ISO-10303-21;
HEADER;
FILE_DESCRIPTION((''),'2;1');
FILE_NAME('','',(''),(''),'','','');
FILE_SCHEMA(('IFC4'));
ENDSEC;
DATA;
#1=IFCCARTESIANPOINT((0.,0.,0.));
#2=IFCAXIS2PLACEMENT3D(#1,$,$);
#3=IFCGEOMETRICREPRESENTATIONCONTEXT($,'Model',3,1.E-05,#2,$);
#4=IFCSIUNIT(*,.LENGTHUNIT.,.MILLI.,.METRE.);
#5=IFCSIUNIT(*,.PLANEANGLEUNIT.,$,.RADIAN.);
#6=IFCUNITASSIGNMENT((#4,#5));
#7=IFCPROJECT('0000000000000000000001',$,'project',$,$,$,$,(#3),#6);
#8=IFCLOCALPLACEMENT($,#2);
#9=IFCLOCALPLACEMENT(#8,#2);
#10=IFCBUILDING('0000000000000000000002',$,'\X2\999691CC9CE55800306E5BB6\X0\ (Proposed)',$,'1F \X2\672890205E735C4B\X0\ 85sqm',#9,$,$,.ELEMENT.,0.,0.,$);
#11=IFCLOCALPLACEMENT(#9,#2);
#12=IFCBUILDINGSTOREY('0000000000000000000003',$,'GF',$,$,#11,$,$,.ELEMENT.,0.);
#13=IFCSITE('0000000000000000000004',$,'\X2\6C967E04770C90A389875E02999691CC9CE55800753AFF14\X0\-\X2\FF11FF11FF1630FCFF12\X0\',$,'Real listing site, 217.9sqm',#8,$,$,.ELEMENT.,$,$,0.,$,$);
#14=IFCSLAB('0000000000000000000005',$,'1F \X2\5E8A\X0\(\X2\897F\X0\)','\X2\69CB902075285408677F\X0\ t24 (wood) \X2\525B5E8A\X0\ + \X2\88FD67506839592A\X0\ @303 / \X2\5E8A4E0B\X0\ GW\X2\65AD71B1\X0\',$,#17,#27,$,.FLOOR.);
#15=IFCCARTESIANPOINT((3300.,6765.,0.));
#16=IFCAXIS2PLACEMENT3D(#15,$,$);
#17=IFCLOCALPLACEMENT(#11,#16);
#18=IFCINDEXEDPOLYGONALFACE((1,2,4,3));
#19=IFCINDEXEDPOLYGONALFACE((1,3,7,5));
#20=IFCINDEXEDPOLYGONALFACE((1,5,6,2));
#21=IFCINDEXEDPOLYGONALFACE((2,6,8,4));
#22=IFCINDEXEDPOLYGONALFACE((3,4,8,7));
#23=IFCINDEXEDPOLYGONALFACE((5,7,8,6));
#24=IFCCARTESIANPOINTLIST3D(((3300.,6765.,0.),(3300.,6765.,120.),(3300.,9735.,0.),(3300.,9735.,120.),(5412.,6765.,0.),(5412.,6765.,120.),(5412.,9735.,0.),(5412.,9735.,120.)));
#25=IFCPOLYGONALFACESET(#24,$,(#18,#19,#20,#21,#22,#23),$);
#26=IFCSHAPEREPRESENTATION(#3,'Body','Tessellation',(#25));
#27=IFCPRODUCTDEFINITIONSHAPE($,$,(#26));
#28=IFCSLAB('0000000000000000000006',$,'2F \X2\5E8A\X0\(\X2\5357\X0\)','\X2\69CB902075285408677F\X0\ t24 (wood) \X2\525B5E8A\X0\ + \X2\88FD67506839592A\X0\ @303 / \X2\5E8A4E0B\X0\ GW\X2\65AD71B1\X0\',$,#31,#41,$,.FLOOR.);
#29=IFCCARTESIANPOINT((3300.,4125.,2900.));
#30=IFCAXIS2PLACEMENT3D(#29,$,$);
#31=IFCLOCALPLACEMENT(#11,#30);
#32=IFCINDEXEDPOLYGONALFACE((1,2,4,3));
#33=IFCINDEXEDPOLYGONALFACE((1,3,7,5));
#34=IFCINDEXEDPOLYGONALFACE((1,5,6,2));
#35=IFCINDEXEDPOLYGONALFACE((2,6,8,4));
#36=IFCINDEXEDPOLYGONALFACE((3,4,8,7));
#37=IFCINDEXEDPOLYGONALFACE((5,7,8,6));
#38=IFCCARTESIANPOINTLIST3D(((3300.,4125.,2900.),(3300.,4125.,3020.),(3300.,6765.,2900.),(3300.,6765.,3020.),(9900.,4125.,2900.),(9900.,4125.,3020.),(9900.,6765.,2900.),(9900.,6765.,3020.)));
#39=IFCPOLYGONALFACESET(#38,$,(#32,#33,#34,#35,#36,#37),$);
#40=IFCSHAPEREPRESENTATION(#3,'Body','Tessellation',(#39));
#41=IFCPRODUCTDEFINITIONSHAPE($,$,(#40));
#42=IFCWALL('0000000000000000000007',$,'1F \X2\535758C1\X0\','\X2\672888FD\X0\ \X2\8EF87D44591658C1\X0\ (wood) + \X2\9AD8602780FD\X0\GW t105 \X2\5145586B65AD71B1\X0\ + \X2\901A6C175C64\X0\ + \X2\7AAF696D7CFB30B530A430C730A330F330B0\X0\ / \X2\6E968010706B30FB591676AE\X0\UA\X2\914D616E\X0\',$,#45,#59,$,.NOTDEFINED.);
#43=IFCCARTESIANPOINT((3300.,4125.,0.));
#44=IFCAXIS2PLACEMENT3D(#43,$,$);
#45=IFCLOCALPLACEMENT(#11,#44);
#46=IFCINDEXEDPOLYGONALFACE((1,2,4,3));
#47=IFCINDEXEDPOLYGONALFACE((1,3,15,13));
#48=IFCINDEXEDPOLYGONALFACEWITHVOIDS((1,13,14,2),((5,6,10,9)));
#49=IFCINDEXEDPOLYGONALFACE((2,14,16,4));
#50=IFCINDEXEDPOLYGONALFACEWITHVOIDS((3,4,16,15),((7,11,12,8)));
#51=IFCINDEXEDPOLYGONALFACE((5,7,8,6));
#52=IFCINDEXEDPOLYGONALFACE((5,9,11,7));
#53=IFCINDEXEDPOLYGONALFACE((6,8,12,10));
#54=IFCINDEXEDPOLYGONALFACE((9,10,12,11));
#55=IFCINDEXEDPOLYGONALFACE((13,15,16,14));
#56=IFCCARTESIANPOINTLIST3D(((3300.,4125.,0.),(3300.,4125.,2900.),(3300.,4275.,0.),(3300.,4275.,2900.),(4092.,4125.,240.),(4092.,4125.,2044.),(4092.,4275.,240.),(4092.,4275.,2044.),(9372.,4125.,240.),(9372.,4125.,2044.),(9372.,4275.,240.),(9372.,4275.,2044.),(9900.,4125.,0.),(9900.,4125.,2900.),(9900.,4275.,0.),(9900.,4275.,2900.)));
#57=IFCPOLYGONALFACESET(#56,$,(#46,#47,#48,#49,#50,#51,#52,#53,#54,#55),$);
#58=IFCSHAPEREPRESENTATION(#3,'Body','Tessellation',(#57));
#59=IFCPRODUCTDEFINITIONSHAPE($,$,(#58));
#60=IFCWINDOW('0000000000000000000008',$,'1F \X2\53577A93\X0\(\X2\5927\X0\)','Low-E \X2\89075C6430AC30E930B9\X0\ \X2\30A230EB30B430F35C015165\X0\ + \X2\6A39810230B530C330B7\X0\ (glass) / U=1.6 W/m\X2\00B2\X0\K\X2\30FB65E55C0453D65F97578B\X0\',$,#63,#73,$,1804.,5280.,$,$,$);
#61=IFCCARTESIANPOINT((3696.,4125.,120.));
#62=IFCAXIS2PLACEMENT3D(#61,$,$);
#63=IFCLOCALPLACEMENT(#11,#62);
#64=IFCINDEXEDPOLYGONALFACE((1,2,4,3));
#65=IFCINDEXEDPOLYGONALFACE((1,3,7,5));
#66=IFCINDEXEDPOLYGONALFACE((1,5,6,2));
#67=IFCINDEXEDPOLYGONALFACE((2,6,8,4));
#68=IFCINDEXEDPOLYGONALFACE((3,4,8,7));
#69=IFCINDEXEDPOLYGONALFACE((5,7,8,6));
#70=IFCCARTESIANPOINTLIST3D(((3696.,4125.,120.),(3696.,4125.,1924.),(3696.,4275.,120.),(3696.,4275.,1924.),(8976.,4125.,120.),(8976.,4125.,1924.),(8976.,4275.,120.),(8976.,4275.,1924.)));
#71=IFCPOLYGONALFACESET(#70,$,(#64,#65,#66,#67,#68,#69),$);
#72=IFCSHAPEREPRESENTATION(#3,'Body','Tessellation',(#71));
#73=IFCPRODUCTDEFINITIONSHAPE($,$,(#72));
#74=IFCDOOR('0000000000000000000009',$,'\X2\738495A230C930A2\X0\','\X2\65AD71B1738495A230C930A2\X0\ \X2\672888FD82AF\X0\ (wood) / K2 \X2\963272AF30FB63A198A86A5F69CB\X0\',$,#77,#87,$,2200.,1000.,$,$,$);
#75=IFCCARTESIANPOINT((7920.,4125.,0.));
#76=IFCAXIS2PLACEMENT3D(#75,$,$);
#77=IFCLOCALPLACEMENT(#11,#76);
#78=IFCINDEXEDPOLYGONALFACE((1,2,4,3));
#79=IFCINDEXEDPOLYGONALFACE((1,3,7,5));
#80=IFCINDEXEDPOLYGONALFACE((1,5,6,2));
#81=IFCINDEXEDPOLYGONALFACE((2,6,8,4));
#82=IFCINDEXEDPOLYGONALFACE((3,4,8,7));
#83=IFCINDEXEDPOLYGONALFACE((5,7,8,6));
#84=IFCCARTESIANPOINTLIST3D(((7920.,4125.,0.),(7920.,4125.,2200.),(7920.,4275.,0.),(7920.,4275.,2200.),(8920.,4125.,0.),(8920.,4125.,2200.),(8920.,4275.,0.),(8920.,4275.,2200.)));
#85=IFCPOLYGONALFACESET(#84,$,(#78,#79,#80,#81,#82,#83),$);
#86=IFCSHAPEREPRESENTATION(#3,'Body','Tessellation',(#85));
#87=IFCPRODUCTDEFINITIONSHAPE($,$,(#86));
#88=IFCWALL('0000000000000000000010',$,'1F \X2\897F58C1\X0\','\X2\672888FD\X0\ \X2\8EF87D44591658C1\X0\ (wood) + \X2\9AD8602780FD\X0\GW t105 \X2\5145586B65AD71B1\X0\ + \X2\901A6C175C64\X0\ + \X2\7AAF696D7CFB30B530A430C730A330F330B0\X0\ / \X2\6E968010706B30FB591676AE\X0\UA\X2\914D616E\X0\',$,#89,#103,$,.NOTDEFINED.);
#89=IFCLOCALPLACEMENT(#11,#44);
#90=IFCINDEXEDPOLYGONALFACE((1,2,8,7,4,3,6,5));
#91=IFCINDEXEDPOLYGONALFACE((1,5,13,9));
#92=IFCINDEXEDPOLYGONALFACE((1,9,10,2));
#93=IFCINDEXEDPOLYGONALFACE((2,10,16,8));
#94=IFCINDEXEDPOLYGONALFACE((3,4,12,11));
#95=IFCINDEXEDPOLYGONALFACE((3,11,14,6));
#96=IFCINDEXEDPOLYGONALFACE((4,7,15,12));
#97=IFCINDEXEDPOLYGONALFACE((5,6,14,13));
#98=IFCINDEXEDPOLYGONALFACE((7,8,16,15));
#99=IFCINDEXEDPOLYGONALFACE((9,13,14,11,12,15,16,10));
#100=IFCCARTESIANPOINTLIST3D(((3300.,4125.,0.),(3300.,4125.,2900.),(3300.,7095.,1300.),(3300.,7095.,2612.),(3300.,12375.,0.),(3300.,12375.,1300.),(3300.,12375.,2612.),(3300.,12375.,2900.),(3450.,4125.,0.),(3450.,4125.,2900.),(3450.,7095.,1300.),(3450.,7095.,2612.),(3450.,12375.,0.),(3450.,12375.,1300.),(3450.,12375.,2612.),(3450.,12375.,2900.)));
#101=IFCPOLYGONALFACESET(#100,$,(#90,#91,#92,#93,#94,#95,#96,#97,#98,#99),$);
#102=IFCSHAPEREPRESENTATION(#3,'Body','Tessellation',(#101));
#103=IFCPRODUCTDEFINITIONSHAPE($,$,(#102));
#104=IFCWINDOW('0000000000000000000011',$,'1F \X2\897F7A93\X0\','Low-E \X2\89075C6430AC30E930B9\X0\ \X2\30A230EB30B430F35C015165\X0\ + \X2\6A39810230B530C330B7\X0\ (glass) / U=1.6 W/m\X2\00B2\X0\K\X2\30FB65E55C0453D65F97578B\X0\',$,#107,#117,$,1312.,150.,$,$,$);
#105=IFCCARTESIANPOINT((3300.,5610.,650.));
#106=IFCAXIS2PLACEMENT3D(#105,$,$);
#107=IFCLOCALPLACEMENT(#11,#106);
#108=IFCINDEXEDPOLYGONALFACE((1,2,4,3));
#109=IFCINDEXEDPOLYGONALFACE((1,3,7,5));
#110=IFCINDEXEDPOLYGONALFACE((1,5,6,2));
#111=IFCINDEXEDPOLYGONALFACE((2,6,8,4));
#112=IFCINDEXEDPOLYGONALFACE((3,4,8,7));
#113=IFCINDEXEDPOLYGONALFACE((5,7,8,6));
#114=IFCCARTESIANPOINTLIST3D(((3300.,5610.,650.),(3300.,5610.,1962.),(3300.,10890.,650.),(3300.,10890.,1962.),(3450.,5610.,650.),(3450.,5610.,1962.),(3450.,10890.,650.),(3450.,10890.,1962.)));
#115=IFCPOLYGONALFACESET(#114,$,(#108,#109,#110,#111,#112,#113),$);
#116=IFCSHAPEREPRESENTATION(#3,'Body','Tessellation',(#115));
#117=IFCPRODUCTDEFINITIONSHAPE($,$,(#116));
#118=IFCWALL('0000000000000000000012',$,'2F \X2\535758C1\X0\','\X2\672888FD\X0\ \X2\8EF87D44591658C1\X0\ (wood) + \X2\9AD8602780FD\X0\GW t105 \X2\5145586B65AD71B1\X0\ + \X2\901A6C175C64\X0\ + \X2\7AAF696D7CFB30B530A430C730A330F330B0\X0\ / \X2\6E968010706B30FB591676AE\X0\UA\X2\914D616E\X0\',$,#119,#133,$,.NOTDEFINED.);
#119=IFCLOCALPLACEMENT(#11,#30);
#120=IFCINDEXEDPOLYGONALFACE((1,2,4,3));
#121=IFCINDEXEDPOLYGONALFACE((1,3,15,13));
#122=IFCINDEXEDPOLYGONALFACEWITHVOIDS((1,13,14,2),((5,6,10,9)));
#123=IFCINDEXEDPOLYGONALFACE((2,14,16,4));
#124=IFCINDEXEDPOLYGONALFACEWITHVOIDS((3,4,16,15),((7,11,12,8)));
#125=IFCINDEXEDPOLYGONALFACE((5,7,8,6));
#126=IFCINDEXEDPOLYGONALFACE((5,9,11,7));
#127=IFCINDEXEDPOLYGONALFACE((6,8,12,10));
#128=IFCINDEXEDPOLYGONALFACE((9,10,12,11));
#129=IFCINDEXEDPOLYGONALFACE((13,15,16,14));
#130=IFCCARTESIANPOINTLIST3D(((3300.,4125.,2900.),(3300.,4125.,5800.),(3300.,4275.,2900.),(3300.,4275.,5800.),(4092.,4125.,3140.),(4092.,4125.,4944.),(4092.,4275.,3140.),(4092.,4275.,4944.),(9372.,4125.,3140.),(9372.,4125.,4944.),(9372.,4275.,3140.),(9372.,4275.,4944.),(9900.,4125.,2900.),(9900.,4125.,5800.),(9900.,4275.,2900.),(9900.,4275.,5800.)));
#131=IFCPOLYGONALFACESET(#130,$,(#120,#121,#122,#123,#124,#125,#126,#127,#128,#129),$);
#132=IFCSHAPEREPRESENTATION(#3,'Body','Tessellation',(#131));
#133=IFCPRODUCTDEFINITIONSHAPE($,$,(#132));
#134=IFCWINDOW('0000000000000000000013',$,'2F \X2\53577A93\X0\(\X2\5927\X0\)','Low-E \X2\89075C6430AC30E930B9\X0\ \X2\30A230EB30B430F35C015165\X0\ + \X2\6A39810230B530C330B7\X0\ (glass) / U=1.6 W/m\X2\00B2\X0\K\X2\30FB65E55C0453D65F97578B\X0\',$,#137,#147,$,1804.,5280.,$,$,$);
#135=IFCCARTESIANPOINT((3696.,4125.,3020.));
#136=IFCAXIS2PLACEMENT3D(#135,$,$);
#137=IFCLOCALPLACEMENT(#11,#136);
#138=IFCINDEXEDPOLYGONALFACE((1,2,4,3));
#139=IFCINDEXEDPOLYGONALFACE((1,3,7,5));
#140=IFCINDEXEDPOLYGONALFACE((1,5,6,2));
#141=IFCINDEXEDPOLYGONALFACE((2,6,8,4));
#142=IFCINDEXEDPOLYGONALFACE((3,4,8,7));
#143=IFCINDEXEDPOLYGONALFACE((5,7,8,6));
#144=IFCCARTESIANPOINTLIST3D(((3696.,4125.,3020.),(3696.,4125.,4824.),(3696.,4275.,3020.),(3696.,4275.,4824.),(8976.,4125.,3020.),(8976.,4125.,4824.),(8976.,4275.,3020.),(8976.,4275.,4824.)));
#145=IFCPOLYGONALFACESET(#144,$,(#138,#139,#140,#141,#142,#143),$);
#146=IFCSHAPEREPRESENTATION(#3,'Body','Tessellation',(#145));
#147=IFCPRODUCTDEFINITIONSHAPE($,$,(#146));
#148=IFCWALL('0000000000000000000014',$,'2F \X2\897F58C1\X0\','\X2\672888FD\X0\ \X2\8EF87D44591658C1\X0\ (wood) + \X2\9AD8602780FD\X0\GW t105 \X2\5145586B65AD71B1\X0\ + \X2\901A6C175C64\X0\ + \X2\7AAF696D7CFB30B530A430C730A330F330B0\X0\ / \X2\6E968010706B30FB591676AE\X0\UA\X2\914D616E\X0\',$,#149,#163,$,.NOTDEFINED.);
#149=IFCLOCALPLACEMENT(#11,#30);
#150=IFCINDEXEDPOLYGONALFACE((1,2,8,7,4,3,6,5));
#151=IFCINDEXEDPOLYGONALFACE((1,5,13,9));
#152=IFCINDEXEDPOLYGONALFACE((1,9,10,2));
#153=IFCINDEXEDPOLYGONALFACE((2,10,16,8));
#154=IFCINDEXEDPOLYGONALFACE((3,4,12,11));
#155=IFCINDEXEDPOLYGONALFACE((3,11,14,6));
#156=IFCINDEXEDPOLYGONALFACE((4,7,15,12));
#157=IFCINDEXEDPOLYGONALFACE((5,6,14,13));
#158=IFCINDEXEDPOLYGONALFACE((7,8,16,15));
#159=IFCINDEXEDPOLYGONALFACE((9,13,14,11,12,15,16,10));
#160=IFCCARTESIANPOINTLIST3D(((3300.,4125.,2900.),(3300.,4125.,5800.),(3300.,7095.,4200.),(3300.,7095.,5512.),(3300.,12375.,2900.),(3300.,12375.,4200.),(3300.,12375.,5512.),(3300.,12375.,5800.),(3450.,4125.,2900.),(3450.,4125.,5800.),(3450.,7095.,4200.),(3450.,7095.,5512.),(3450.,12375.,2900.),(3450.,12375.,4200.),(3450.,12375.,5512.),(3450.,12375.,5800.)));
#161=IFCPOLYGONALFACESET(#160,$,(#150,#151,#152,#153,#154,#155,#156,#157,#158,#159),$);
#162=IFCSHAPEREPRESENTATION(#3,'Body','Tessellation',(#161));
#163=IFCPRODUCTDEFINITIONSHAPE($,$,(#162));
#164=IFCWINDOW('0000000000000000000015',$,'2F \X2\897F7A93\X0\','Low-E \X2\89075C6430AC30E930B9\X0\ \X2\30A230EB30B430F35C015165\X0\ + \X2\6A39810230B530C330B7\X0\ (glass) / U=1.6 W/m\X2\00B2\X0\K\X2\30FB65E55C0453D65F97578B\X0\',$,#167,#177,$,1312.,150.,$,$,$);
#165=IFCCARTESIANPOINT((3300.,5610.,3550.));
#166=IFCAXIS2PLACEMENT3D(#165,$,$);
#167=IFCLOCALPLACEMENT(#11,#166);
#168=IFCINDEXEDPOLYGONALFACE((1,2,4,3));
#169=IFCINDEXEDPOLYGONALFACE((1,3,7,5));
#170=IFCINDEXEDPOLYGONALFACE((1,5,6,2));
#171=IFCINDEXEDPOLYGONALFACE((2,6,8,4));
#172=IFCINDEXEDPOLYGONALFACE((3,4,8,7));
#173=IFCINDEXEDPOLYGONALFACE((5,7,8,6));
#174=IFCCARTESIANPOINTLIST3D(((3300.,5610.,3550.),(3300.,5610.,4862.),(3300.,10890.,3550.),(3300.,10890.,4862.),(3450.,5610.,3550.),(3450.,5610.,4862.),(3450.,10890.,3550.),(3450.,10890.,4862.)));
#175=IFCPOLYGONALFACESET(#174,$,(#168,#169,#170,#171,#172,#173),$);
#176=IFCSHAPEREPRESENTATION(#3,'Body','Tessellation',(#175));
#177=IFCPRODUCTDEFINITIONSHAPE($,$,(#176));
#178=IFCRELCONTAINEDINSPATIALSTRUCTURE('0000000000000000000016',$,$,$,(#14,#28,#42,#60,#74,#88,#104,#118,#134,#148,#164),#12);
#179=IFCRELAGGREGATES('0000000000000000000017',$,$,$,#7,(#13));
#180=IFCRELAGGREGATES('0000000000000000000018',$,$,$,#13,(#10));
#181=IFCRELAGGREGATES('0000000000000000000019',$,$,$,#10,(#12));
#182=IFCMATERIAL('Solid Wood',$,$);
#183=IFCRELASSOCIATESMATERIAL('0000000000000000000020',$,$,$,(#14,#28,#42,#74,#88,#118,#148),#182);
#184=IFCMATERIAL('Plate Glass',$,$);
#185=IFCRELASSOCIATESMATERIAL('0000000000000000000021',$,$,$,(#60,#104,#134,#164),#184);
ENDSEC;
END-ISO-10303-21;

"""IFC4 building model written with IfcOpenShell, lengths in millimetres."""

from ifc_helpers import new_model, si_unit, frame, frame_2d, origin, place, context, project, spatial, rectangle, extrude, material, element, fill, save


model = new_model("IFC4")

# Units and contexts
model_context = context("Model", 3, precision=1e-05, world=origin())
ifc_project = project(units=[si_unit("LENGTHUNIT", "METRE", prefix="MILLI"), si_unit("PLANEANGLEUNIT", "RADIAN")], contexts=[model_context])

# Site, building, storey
site_placement = place(None, origin())
site = spatial("IfcSite", under=ifc_project, at=site_placement, Name="沖縄県那覇市首里鳥堀町４-１１６ー２", ObjectType="Real listing site, 217.9sqm", CompositionType="ELEMENT", RefElevation=0.0)
building_placement = place(site_placement, origin())
building = spatial("IfcBuilding", under=site, at=building_placement, Name="首里鳥堀の家 (Proposed)", ObjectType="1F 木造平屋 85sqm", CompositionType="ELEMENT", ElevationOfRefHeight=0.0, ElevationOfTerrain=0.0)
storey_placement = place(building_placement, origin())
storey = spatial("IfcBuildingStorey", under=building, at=storey_placement, Name="GF", CompositionType="ELEMENT", Elevation=0.0)

# Slabs
ifc_material_1 = material(Name="Solid Wood")
slab_1_placement = place(storey_placement, frame((3300.0, 6765.0, 0.0)))
element("IfcSlab", 1, at=slab_1_placement, inside=storey, material=ifc_material_1, Name="1F 床(西)", Description="構造用合板 t24 (wood) 剛床 + 製材根太 @303 / 床下 GW断熱", PredefinedType="FLOOR", context=model_context, shape_type="SweptSolid", body=[
    extrude(rectangle(XDim=2112.0, YDim=2970.0, at=frame_2d((1056.0, 1485.0))), frame((3300.0, 6765.0, 0.0)), (0.0, 0.0, 1.0), 120.0),
])
slab_2_placement = place(storey_placement, frame((3300.0, 4125.0, 2900.0)))
element("IfcSlab", 2, at=slab_2_placement, inside=storey, material=ifc_material_1, Name="2F 床(南)", Description="構造用合板 t24 (wood) 剛床 + 製材根太 @303 / 床下 GW断熱", PredefinedType="FLOOR", context=model_context, shape_type="SweptSolid", body=[
    extrude(rectangle(XDim=6600.0, YDim=2640.0, at=frame_2d((3300.0, 1320.0))), frame((3300.0, 4125.0, 2900.0)), (0.0, 0.0, 1.0), 120.0),
])

# Wall, openings, window, door
wall_1_placement = place(storey_placement, frame((3300.0, 4125.0, 0.0)))
wall_1 = element("IfcWall", 3, at=wall_1_placement, inside=storey, material=ifc_material_1, Name="1F 南壁", Description="木製 軸組外壁 (wood) + 高性能GW t105 充填断熱 + 通気層 + 窯業系サイディング / 準耐火・外皮UA配慮", PredefinedType="NOTDEFINED", context=model_context, shape_type="SweptSolid", body=[
    extrude(rectangle(XDim=6600.0, YDim=150.0, at=frame_2d((3300.0, 75.0))), frame((3300.0, 4125.0, 0.0)), (0.0, 0.0, 1.0), 2900.0),
])
opening_1_placement = place(storey_placement, frame((3696.0, 4125.0, 120.0)))
opening_1 = element("IfcOpeningElement", 4, at=opening_1_placement, cuts=wall_1, PredefinedType="NOTDEFINED", context=model_context, shape_type="SweptSolid", body=[
    extrude(rectangle(XDim=5280.0, YDim=150.0, at=frame_2d((2640.0, 75.0))), frame((3696.0, 4125.0, 120.0)), (0.0, 0.0, 1.0), 1804.0),
])
opening_2_placement = place(storey_placement, frame((7920.0, 4125.0, 0.0)))
opening_2 = element("IfcOpeningElement", 5, at=opening_2_placement, cuts=wall_1, PredefinedType="NOTDEFINED", context=model_context, shape_type="SweptSolid", body=[
    extrude(rectangle(XDim=1000.0, YDim=150.0, at=frame_2d((500.0, 75.0))), frame((7920.0, 4125.0, 0.0)), (0.0, 0.0, 1.0), 2200.0),
])
ifc_material_2 = material(Name="Plate Glass")
window_1_placement = place(storey_placement, frame((3696.0, 4125.0, 120.0)))
window_1 = element("IfcWindow", 6, at=window_1_placement, inside=storey, material=ifc_material_2, Name="1F 南窓(大)", Description="Low-E 複層ガラス アルゴン封入 + 樹脂サッシ (glass) / U=1.6 W/m²K・日射取得型", OverallHeight=1804.0, OverallWidth=5280.0, context=model_context, shape_type="SweptSolid", body=[
    extrude(rectangle(XDim=5280.0, YDim=150.0, at=frame_2d((2640.0, 75.0))), frame((3696.0, 4125.0, 120.0)), (0.0, 0.0, 1.0), 1804.0),
])
fill(opening_1, window_1)
door_placement = place(storey_placement, frame((7920.0, 4125.0, 0.0)))
door = element("IfcDoor", 7, at=door_placement, inside=storey, material=ifc_material_1, Name="玄関ドア", Description="断熱玄関ドア 木製芯 (wood) / K2 防犯・採風機構", OverallHeight=2200.0, OverallWidth=1000.0, context=model_context, shape_type="SweptSolid", body=[
    extrude(rectangle(XDim=1000.0, YDim=150.0, at=frame_2d((500.0, 75.0))), frame((7920.0, 4125.0, 0.0)), (0.0, 0.0, 1.0), 2200.0),
])
fill(opening_2, door)

# Walls, openings, windows
wall_2_placement = place(storey_placement, frame((3300.0, 4125.0, 0.0)))
wall_2 = element("IfcWall", 8, at=wall_2_placement, inside=storey, material=ifc_material_1, Name="1F 西壁", Description="木製 軸組外壁 (wood) + 高性能GW t105 充填断熱 + 通気層 + 窯業系サイディング / 準耐火・外皮UA配慮", PredefinedType="NOTDEFINED", context=model_context, shape_type="SweptSolid", body=[
    extrude(rectangle(XDim=150.0, YDim=8250.0, at=frame_2d((75.0, 4125.0))), frame((3300.0, 4125.0, 0.0)), (0.0, 0.0, 1.0), 2900.0),
])
opening_3_placement = place(storey_placement, frame((3300.0, 5610.0, 650.0)))
opening_3 = element("IfcOpeningElement", 9, at=opening_3_placement, cuts=wall_2, PredefinedType="NOTDEFINED", context=model_context, shape_type="SweptSolid", body=[
    extrude(rectangle(XDim=150.0, YDim=5280.0, at=frame_2d((75.0, 2640.0))), frame((3300.0, 5610.0, 650.0)), (0.0, 0.0, 1.0), 1312.0),
])
window_2_placement = place(storey_placement, frame((3300.0, 5610.0, 650.0)))
window_2 = element("IfcWindow", 10, at=window_2_placement, inside=storey, material=ifc_material_2, Name="1F 西窓", Description="Low-E 複層ガラス アルゴン封入 + 樹脂サッシ (glass) / U=1.6 W/m²K・日射取得型", OverallHeight=1312.0, OverallWidth=150.0, context=model_context, shape_type="SweptSolid", body=[
    extrude(rectangle(XDim=150.0, YDim=5280.0, at=frame_2d((75.0, 2640.0))), frame((3300.0, 5610.0, 650.0)), (0.0, 0.0, 1.0), 1312.0),
])
fill(opening_3, window_2)
wall_3_placement = place(storey_placement, frame((3300.0, 4125.0, 2900.0)))
wall_3 = element("IfcWall", 11, at=wall_3_placement, inside=storey, material=ifc_material_1, Name="2F 南壁", Description="木製 軸組外壁 (wood) + 高性能GW t105 充填断熱 + 通気層 + 窯業系サイディング / 準耐火・外皮UA配慮", PredefinedType="NOTDEFINED", context=model_context, shape_type="SweptSolid", body=[
    extrude(rectangle(XDim=6600.0, YDim=150.0, at=frame_2d((3300.0, 75.0))), frame((3300.0, 4125.0, 2900.0)), (0.0, 0.0, 1.0), 2900.0),
])
opening_4_placement = place(storey_placement, frame((3696.0, 4125.0, 3020.0)))
opening_4 = element("IfcOpeningElement", 12, at=opening_4_placement, cuts=wall_3, PredefinedType="NOTDEFINED", context=model_context, shape_type="SweptSolid", body=[
    extrude(rectangle(XDim=5280.0, YDim=150.0, at=frame_2d((2640.0, 75.0))), frame((3696.0, 4125.0, 3020.0)), (0.0, 0.0, 1.0), 1804.0),
])
window_3_placement = place(storey_placement, frame((3696.0, 4125.0, 3020.0)))
window_3 = element("IfcWindow", 13, at=window_3_placement, inside=storey, material=ifc_material_2, Name="2F 南窓(大)", Description="Low-E 複層ガラス アルゴン封入 + 樹脂サッシ (glass) / U=1.6 W/m²K・日射取得型", OverallHeight=1804.0, OverallWidth=5280.0, context=model_context, shape_type="SweptSolid", body=[
    extrude(rectangle(XDim=5280.0, YDim=150.0, at=frame_2d((2640.0, 75.0))), frame((3696.0, 4125.0, 3020.0)), (0.0, 0.0, 1.0), 1804.0),
])
fill(opening_4, window_3)
wall_4_placement = place(storey_placement, frame((3300.0, 4125.0, 2900.0)))
wall_4 = element("IfcWall", 14, at=wall_4_placement, inside=storey, material=ifc_material_1, Name="2F 西壁", Description="木製 軸組外壁 (wood) + 高性能GW t105 充填断熱 + 通気層 + 窯業系サイディング / 準耐火・外皮UA配慮", PredefinedType="NOTDEFINED", context=model_context, shape_type="SweptSolid", body=[
    extrude(rectangle(XDim=150.0, YDim=8250.0, at=frame_2d((75.0, 4125.0))), frame((3300.0, 4125.0, 2900.0)), (0.0, 0.0, 1.0), 2900.0),
])
opening_5_placement = place(storey_placement, frame((3300.0, 5610.0, 3550.0)))
opening_5 = element("IfcOpeningElement", 15, at=opening_5_placement, cuts=wall_4, PredefinedType="NOTDEFINED", context=model_context, shape_type="SweptSolid", body=[
    extrude(rectangle(XDim=150.0, YDim=5280.0, at=frame_2d((75.0, 2640.0))), frame((3300.0, 5610.0, 3550.0)), (0.0, 0.0, 1.0), 1312.0),
])
window_4_placement = place(storey_placement, frame((3300.0, 5610.0, 3550.0)))
window_4 = element("IfcWindow", 16, at=window_4_placement, inside=storey, material=ifc_material_2, Name="2F 西窓", Description="Low-E 複層ガラス アルゴン封入 + 樹脂サッシ (glass) / U=1.6 W/m²K・日射取得型", OverallHeight=1312.0, OverallWidth=150.0, context=model_context, shape_type="SweptSolid", body=[
    extrude(rectangle(XDim=150.0, YDim=5280.0, at=frame_2d((75.0, 2640.0))), frame((3300.0, 5610.0, 3550.0)), (0.0, 0.0, 1.0), 1312.0),
])
fill(opening_5, window_4)

save(model, "model.ifc")
